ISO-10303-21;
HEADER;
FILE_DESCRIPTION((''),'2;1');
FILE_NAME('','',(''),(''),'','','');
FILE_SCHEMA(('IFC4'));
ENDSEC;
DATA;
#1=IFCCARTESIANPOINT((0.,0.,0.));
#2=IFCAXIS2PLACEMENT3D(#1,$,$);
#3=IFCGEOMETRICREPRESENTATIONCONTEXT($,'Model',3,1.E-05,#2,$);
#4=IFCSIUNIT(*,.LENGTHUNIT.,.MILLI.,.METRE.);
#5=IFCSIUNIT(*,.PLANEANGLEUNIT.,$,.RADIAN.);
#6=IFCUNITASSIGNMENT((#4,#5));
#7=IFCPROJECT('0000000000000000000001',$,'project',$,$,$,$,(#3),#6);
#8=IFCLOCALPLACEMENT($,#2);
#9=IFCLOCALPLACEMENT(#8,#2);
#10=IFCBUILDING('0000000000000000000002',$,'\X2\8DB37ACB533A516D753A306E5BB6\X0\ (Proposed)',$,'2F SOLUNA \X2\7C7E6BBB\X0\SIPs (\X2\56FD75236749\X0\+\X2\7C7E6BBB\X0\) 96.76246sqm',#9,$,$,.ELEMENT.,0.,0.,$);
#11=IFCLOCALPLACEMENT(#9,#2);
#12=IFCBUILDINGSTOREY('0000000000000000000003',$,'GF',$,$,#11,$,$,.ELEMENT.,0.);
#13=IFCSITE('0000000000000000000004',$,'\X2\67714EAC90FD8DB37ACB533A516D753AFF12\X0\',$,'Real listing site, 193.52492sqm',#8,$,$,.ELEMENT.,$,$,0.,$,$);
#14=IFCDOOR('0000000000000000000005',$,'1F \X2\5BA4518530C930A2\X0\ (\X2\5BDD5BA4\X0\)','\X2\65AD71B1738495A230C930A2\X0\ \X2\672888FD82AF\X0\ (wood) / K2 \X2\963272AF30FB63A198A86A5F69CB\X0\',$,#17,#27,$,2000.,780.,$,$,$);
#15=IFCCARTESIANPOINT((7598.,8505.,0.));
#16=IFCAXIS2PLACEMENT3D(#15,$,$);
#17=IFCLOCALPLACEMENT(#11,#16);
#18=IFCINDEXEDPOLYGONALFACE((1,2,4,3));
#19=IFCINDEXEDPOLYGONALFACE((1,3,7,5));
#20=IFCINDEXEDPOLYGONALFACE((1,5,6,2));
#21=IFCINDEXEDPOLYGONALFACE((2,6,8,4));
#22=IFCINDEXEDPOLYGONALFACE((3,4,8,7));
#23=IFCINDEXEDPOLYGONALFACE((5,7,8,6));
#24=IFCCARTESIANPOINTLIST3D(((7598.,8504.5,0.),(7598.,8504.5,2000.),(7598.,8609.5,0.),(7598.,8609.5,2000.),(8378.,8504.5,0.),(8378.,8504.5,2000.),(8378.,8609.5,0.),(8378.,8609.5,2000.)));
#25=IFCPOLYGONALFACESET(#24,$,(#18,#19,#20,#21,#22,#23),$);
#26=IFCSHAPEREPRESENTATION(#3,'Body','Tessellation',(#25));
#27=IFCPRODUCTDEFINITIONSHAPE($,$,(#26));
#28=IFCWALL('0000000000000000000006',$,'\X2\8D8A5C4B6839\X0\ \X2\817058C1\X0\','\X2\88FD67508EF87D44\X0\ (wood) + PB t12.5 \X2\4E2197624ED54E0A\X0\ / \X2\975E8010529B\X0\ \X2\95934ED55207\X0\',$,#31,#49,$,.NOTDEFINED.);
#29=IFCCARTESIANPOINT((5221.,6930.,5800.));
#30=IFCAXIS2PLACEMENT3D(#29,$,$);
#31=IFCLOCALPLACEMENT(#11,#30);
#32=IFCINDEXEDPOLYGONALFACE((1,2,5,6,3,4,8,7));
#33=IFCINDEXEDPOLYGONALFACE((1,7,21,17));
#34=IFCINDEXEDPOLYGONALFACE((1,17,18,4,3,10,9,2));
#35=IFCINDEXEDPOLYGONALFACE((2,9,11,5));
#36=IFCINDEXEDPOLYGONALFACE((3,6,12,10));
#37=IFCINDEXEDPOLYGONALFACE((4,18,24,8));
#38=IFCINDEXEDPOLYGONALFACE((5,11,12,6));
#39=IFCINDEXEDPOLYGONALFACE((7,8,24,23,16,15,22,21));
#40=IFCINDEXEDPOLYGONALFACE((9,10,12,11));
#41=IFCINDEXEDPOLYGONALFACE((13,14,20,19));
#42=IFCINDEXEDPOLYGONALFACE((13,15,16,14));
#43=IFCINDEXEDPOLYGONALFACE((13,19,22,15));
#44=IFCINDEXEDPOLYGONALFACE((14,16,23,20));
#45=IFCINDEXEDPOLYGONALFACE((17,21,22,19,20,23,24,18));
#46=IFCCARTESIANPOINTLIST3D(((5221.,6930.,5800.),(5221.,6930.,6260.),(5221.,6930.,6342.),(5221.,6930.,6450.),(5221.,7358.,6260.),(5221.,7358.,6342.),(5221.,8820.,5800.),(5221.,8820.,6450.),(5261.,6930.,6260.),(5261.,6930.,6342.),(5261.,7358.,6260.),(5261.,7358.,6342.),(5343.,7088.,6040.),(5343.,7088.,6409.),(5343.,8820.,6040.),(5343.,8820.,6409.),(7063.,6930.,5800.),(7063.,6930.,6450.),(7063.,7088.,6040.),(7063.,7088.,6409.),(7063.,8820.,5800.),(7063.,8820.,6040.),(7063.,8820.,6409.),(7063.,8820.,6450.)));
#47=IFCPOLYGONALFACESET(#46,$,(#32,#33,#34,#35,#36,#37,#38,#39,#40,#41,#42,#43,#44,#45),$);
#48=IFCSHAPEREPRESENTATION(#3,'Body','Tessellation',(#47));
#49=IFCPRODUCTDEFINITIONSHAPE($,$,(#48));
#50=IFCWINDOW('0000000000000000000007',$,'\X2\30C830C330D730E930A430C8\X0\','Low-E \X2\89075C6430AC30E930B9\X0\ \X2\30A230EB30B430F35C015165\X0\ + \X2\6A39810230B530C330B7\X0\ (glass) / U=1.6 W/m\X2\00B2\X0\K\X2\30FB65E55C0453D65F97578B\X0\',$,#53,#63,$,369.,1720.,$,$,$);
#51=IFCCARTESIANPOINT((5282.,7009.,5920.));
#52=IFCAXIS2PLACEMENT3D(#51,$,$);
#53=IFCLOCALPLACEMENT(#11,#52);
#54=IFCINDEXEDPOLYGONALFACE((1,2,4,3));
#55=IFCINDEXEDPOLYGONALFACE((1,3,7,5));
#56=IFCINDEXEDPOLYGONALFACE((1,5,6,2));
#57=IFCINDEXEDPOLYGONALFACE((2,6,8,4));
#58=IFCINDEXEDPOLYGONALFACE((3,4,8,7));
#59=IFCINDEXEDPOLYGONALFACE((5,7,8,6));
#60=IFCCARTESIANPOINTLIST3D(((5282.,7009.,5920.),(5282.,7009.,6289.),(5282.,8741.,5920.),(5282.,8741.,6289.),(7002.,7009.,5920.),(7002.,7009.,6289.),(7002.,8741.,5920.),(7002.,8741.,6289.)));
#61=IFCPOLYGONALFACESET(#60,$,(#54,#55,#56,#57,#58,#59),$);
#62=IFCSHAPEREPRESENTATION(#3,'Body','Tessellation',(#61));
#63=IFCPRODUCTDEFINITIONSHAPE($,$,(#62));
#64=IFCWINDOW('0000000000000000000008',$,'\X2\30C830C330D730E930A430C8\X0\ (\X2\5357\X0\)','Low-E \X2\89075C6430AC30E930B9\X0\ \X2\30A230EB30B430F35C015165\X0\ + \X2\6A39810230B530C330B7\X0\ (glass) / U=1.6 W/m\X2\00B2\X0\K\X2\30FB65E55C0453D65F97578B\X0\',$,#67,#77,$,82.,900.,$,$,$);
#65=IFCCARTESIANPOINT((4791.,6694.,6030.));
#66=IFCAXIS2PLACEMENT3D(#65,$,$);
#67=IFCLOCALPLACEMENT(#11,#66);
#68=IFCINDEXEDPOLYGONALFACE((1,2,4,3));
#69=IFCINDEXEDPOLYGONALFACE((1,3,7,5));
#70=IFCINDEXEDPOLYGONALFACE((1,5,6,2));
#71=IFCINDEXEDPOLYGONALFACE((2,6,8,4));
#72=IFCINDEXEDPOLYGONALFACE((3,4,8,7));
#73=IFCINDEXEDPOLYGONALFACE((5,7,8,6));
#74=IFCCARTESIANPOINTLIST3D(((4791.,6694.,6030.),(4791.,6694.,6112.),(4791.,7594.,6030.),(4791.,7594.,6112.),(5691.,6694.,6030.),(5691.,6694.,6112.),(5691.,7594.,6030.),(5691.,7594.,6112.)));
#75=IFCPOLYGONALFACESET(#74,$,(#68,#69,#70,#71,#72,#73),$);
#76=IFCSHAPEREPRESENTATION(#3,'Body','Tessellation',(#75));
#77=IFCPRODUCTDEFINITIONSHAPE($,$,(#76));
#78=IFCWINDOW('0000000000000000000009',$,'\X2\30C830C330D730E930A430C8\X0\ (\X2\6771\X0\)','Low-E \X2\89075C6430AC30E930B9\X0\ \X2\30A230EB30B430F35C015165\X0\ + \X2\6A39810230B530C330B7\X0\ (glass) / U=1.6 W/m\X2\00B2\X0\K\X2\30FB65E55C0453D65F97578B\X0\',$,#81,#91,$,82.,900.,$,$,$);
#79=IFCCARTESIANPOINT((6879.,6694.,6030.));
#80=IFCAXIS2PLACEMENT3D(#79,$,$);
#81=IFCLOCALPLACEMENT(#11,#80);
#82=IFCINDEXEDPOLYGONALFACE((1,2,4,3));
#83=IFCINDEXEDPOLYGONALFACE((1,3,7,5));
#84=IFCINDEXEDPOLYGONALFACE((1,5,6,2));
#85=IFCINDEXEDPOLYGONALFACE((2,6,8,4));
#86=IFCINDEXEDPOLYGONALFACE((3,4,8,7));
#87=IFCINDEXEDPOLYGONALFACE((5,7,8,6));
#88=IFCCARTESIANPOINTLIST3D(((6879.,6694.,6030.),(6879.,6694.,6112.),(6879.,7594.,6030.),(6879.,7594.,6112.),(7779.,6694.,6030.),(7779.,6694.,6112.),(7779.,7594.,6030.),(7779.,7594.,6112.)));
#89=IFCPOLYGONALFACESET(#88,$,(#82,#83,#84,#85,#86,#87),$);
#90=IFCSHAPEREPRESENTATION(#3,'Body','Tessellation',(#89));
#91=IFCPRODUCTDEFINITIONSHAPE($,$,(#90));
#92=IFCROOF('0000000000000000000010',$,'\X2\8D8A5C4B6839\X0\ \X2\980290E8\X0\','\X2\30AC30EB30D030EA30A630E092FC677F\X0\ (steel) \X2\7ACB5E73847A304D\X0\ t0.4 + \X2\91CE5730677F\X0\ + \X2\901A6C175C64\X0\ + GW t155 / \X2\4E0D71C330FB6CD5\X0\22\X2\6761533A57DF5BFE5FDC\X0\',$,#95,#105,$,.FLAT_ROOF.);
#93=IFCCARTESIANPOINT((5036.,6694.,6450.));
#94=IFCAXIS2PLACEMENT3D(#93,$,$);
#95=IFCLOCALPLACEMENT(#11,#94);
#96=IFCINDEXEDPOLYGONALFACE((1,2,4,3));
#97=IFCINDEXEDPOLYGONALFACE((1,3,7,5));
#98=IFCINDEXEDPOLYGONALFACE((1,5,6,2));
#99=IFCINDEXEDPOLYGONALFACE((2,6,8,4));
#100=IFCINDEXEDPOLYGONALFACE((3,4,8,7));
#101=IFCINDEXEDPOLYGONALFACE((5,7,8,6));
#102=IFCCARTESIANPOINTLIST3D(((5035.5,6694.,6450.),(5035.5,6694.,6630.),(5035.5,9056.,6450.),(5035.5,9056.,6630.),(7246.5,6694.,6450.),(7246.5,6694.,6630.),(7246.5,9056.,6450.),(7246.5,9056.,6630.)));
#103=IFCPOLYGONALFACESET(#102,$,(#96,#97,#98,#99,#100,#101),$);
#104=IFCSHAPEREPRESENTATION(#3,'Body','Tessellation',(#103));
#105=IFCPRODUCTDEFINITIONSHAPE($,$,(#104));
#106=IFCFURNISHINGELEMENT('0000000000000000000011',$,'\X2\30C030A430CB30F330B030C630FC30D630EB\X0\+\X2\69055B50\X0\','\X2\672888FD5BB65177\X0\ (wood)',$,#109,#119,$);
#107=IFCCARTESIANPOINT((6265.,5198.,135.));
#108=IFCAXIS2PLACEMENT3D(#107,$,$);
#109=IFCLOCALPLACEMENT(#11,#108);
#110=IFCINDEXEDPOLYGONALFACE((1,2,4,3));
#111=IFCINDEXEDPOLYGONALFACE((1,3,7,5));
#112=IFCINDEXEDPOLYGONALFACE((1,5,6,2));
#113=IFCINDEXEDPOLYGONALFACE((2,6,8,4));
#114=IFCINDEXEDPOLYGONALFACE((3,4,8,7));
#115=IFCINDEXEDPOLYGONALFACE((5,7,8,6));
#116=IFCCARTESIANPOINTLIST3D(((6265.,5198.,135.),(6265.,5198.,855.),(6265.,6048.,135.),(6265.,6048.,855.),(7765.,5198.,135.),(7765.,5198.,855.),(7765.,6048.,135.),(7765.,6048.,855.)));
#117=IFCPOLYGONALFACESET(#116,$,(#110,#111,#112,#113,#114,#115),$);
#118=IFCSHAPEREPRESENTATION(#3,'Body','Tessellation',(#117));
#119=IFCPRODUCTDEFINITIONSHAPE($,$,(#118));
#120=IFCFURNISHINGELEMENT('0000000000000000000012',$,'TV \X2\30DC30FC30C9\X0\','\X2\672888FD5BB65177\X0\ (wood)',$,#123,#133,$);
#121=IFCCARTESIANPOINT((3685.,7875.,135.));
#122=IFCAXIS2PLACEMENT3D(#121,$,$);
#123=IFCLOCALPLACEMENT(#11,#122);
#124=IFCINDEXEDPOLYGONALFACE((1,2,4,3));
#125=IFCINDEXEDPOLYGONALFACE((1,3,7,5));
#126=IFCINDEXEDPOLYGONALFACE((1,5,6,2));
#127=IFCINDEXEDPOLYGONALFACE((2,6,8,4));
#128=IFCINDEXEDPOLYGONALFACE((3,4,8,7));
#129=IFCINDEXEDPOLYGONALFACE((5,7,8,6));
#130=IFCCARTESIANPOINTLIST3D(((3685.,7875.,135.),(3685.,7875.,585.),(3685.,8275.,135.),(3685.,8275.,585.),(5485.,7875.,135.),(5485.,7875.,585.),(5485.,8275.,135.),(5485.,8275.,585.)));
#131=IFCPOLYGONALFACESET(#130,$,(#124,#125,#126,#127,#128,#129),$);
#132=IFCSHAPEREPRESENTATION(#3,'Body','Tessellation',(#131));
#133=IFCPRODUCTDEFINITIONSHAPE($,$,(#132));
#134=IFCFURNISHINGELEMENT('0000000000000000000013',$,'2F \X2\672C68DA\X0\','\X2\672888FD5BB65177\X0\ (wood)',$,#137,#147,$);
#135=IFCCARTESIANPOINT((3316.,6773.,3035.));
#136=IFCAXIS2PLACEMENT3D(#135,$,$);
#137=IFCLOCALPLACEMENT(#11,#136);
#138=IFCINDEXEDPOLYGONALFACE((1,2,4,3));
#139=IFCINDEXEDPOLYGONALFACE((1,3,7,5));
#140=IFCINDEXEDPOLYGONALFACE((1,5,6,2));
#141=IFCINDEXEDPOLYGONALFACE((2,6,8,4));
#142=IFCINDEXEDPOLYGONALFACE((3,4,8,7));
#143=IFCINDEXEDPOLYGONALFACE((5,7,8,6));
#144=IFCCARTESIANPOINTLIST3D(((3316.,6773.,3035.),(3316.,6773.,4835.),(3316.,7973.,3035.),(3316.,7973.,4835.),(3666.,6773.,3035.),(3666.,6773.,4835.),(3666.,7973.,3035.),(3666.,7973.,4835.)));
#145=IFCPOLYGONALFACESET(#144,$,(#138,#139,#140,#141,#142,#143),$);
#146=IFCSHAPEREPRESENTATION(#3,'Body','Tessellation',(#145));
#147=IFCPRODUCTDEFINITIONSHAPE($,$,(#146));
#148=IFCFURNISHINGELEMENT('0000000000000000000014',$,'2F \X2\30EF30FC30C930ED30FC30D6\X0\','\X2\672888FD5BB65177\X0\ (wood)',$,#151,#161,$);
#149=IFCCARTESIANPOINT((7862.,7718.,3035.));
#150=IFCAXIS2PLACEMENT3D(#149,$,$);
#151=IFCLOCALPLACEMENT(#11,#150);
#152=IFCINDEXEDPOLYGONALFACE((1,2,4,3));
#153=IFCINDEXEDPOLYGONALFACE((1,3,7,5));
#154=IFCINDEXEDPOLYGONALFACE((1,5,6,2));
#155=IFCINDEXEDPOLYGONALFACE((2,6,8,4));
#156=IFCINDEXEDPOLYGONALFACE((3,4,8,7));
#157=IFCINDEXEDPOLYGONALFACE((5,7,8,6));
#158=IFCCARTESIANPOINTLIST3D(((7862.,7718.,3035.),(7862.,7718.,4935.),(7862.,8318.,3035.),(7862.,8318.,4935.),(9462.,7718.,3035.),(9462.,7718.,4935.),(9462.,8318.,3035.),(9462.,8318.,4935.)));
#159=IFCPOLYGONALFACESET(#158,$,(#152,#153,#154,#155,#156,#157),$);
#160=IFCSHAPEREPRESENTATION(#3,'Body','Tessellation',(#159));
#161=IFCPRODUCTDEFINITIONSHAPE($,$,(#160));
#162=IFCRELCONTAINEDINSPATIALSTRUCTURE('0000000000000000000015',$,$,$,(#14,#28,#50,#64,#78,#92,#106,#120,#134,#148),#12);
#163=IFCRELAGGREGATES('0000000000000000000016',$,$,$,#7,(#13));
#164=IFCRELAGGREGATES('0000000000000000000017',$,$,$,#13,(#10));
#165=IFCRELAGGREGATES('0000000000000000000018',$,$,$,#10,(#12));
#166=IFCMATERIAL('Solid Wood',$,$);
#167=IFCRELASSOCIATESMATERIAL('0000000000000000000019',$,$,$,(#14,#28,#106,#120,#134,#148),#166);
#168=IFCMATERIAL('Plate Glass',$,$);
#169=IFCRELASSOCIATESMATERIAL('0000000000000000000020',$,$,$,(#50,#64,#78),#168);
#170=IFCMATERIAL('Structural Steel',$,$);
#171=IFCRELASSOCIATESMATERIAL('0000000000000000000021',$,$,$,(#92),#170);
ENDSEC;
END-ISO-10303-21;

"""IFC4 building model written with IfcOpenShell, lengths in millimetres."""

from ifc_helpers import new_model, si_unit, frame, frame_2d, origin, place, context, project, spatial, rectangle, extrude, material, element, fill, save


model = new_model("IFC4")

# Units and contexts
model_context = context("Model", 3, precision=1e-05, world=origin())
ifc_project = project(units=[si_unit("LENGTHUNIT", "METRE", prefix="MILLI"), si_unit("PLANEANGLEUNIT", "RADIAN")], contexts=[model_context])

# Site, building, storey
site_placement = place(None, origin())
site = spatial("IfcSite", under=ifc_project, at=site_placement, Name="東京都足立区六町２", ObjectType="Real listing site, 193.52492sqm", CompositionType="ELEMENT", RefElevation=0.0)
building_placement = place(site_placement, origin())
building = spatial("IfcBuilding", under=site, at=building_placement, Name="足立区六町の家 (Proposed)", ObjectType="2F SOLUNA 籾殻SIPs (国産杉+籾殻) 96.76246sqm", CompositionType="ELEMENT", ElevationOfRefHeight=0.0, ElevationOfTerrain=0.0)
storey_placement = place(building_placement, origin())
storey = spatial("IfcBuildingStorey", under=building, at=storey_placement, Name="GF", CompositionType="ELEMENT", Elevation=0.0)

# Shared definitions
ifc_material_1 = material(Name="Solid Wood")

# Door
door_placement = place(storey_placement, frame((7598.0, 8505.0, 0.0)))
element("IfcDoor", 1, at=door_placement, inside=storey, material=ifc_material_1, Name="1F 室内ドア (寝室)", Description="断熱玄関ドア 木製芯 (wood) / K2 防犯・採風機構", OverallHeight=2000.0, OverallWidth=780.0, context=model_context, shape_type="SweptSolid", body=[
    extrude(rectangle(XDim=780.0, YDim=105.0, at=frame_2d((390.0, 52.0))), frame((7598.0, 8505.0, 0.0)), (0.0, 0.0, 1.0), 2000.0),
])

# Wall, openings, windows
wall_1_placement = place(storey_placement, frame((5221.0, 6930.0, 5800.0)))
wall_1 = element("IfcWall", 2, at=wall_1_placement, inside=storey, material=ifc_material_1, Name="越屋根 腰壁", Description="製材軸組 (wood) + PB t12.5 両面仕上 / 非耐力 間仕切", PredefinedType="NOTDEFINED", context=model_context, shape_type="SweptSolid", body=[
    extrude(rectangle(XDim=1842.0, YDim=1890.0, at=frame_2d((921.0, 945.0))), frame((5221.0, 6930.0, 5800.0)), (0.0, 0.0, 1.0), 650.0),
])
opening_1_placement = place(storey_placement, frame((5282.0, 7009.0, 5920.0)))
opening_1 = element("IfcOpeningElement", 3, at=opening_1_placement, cuts=wall_1, PredefinedType="NOTDEFINED", context=model_context, shape_type="SweptSolid", body=[
    extrude(rectangle(XDim=1720.0, YDim=1732.0, at=frame_2d((860.0, 866.0))), frame((5282.0, 7009.0, 5920.0)), (0.0, 0.0, 1.0), 369.0),
])
opening_2_placement = place(storey_placement, frame((4791.0, 6694.0, 6030.0)))
opening_2 = element("IfcOpeningElement", 4, at=opening_2_placement, cuts=wall_1, PredefinedType="NOTDEFINED", context=model_context, shape_type="SweptSolid", body=[
    extrude(rectangle(XDim=900.0, YDim=900.0, at=frame_2d((450.0, 450.0))), frame((4791.0, 6694.0, 6030.0)), (0.0, 0.0, 1.0), 82.0),
])
opening_3_placement = place(storey_placement, frame((6879.0, 6694.0, 6030.0)))
opening_3 = element("IfcOpeningElement", 5, at=opening_3_placement, cuts=wall_1, PredefinedType="NOTDEFINED", context=model_context, shape_type="SweptSolid", body=[
    extrude(rectangle(XDim=900.0, YDim=900.0, at=frame_2d((450.0, 450.0))), frame((6879.0, 6694.0, 6030.0)), (0.0, 0.0, 1.0), 82.0),
])
ifc_material_2 = material(Name="Plate Glass")
window_1_placement = place(storey_placement, frame((5282.0, 7009.0, 5920.0)))
window_1 = element("IfcWindow", 6, at=window_1_placement, inside=storey, material=ifc_material_2, Name="トップライト", Description="Low-E 複層ガラス アルゴン封入 + 樹脂サッシ (glass) / U=1.6 W/m²K・日射取得型", OverallHeight=369.0, OverallWidth=1720.0, context=model_context, shape_type="SweptSolid", body=[
    extrude(rectangle(XDim=1720.0, YDim=1732.0, at=frame_2d((860.0, 866.0))), frame((5282.0, 7009.0, 5920.0)), (0.0, 0.0, 1.0), 369.0),
])
fill(opening_1, window_1)
window_2_placement = place(storey_placement, frame((4791.0, 6694.0, 6030.0)))
window_2 = element("IfcWindow", 7, at=window_2_placement, inside=storey, material=ifc_material_2, Name="トップライト (南)", Description="Low-E 複層ガラス アルゴン封入 + 樹脂サッシ (glass) / U=1.6 W/m²K・日射取得型", OverallHeight=82.0, OverallWidth=900.0, context=model_context, shape_type="SweptSolid", body=[
    extrude(rectangle(XDim=900.0, YDim=900.0, at=frame_2d((450.0, 450.0))), frame((4791.0, 6694.0, 6030.0)), (0.0, 0.0, 1.0), 82.0),
])
fill(opening_2, window_2)
window_3_placement = place(storey_placement, frame((6879.0, 6694.0, 6030.0)))
window_3 = element("IfcWindow", 8, at=window_3_placement, inside=storey, material=ifc_material_2, Name="トップライト (東)", Description="Low-E 複層ガラス アルゴン封入 + 樹脂サッシ (glass) / U=1.6 W/m²K・日射取得型", OverallHeight=82.0, OverallWidth=900.0, context=model_context, shape_type="SweptSolid", body=[
    extrude(rectangle(XDim=900.0, YDim=900.0, at=frame_2d((450.0, 450.0))), frame((6879.0, 6694.0, 6030.0)), (0.0, 0.0, 1.0), 82.0),
])
fill(opening_3, window_3)

# Roof
ifc_material_3 = material(Name="Structural Steel")
roof_placement = place(storey_placement, frame((5036.0, 6694.0, 6450.0)))
element("IfcRoof", 9, at=roof_placement, inside=storey, material=ifc_material_3, Name="越屋根 頂部", Description="ガルバリウム鋼板 (steel) 立平葺き t0.4 + 野地板 + 通気層 + GW t155 / 不燃・法22条区域対応", PredefinedType="FLAT_ROOF", context=model_context, shape_type="SweptSolid", body=[
    extrude(rectangle(XDim=2211.0, YDim=2362.0, at=frame_2d((1105.0, 1181.0))), frame((5036.0, 6694.0, 6450.0)), (0.0, 0.0, 1.0), 180.0),
])

# Furnishing elements
furnishing_1_placement = place(storey_placement, frame((6265.0, 5198.0, 135.0)))
element("IfcFurnishingElement", 10, at=furnishing_1_placement, inside=storey, material=ifc_material_1, Name="ダイニングテーブル+椅子", Description="木製家具 (wood)", context=model_context, shape_type="SweptSolid", body=[
    extrude(rectangle(XDim=1500.0, YDim=850.0, at=frame_2d((750.0, 425.0))), frame((6265.0, 5198.0, 135.0)), (0.0, 0.0, 1.0), 720.0),
])
furnishing_2_placement = place(storey_placement, frame((3685.0, 7875.0, 135.0)))
element("IfcFurnishingElement", 11, at=furnishing_2_placement, inside=storey, material=ifc_material_1, Name="TV ボード", Description="木製家具 (wood)", context=model_context, shape_type="SweptSolid", body=[
    extrude(rectangle(XDim=1800.0, YDim=400.0, at=frame_2d((900.0, 200.0))), frame((3685.0, 7875.0, 135.0)), (0.0, 0.0, 1.0), 450.0),
])
furnishing_3_placement = place(storey_placement, frame((3316.0, 6773.0, 3035.0)))
element("IfcFurnishingElement", 12, at=furnishing_3_placement, inside=storey, material=ifc_material_1, Name="2F 本棚", Description="木製家具 (wood)", context=model_context, shape_type="SweptSolid", body=[
    extrude(rectangle(XDim=350.0, YDim=1200.0, at=frame_2d((175.0, 600.0))), frame((3316.0, 6773.0, 3035.0)), (0.0, 0.0, 1.0), 1800.0),
])
furnishing_4_placement = place(storey_placement, frame((7862.0, 7718.0, 3035.0)))
element("IfcFurnishingElement", 13, at=furnishing_4_placement, inside=storey, material=ifc_material_1, Name="2F ワードローブ", Description="木製家具 (wood)", context=model_context, shape_type="SweptSolid", body=[
    extrude(rectangle(XDim=1600.0, YDim=600.0, at=frame_2d((800.0, 300.0))), frame((7862.0, 7718.0, 3035.0)), (0.0, 0.0, 1.0), 1900.0),
])

save(model, "model.ifc")
